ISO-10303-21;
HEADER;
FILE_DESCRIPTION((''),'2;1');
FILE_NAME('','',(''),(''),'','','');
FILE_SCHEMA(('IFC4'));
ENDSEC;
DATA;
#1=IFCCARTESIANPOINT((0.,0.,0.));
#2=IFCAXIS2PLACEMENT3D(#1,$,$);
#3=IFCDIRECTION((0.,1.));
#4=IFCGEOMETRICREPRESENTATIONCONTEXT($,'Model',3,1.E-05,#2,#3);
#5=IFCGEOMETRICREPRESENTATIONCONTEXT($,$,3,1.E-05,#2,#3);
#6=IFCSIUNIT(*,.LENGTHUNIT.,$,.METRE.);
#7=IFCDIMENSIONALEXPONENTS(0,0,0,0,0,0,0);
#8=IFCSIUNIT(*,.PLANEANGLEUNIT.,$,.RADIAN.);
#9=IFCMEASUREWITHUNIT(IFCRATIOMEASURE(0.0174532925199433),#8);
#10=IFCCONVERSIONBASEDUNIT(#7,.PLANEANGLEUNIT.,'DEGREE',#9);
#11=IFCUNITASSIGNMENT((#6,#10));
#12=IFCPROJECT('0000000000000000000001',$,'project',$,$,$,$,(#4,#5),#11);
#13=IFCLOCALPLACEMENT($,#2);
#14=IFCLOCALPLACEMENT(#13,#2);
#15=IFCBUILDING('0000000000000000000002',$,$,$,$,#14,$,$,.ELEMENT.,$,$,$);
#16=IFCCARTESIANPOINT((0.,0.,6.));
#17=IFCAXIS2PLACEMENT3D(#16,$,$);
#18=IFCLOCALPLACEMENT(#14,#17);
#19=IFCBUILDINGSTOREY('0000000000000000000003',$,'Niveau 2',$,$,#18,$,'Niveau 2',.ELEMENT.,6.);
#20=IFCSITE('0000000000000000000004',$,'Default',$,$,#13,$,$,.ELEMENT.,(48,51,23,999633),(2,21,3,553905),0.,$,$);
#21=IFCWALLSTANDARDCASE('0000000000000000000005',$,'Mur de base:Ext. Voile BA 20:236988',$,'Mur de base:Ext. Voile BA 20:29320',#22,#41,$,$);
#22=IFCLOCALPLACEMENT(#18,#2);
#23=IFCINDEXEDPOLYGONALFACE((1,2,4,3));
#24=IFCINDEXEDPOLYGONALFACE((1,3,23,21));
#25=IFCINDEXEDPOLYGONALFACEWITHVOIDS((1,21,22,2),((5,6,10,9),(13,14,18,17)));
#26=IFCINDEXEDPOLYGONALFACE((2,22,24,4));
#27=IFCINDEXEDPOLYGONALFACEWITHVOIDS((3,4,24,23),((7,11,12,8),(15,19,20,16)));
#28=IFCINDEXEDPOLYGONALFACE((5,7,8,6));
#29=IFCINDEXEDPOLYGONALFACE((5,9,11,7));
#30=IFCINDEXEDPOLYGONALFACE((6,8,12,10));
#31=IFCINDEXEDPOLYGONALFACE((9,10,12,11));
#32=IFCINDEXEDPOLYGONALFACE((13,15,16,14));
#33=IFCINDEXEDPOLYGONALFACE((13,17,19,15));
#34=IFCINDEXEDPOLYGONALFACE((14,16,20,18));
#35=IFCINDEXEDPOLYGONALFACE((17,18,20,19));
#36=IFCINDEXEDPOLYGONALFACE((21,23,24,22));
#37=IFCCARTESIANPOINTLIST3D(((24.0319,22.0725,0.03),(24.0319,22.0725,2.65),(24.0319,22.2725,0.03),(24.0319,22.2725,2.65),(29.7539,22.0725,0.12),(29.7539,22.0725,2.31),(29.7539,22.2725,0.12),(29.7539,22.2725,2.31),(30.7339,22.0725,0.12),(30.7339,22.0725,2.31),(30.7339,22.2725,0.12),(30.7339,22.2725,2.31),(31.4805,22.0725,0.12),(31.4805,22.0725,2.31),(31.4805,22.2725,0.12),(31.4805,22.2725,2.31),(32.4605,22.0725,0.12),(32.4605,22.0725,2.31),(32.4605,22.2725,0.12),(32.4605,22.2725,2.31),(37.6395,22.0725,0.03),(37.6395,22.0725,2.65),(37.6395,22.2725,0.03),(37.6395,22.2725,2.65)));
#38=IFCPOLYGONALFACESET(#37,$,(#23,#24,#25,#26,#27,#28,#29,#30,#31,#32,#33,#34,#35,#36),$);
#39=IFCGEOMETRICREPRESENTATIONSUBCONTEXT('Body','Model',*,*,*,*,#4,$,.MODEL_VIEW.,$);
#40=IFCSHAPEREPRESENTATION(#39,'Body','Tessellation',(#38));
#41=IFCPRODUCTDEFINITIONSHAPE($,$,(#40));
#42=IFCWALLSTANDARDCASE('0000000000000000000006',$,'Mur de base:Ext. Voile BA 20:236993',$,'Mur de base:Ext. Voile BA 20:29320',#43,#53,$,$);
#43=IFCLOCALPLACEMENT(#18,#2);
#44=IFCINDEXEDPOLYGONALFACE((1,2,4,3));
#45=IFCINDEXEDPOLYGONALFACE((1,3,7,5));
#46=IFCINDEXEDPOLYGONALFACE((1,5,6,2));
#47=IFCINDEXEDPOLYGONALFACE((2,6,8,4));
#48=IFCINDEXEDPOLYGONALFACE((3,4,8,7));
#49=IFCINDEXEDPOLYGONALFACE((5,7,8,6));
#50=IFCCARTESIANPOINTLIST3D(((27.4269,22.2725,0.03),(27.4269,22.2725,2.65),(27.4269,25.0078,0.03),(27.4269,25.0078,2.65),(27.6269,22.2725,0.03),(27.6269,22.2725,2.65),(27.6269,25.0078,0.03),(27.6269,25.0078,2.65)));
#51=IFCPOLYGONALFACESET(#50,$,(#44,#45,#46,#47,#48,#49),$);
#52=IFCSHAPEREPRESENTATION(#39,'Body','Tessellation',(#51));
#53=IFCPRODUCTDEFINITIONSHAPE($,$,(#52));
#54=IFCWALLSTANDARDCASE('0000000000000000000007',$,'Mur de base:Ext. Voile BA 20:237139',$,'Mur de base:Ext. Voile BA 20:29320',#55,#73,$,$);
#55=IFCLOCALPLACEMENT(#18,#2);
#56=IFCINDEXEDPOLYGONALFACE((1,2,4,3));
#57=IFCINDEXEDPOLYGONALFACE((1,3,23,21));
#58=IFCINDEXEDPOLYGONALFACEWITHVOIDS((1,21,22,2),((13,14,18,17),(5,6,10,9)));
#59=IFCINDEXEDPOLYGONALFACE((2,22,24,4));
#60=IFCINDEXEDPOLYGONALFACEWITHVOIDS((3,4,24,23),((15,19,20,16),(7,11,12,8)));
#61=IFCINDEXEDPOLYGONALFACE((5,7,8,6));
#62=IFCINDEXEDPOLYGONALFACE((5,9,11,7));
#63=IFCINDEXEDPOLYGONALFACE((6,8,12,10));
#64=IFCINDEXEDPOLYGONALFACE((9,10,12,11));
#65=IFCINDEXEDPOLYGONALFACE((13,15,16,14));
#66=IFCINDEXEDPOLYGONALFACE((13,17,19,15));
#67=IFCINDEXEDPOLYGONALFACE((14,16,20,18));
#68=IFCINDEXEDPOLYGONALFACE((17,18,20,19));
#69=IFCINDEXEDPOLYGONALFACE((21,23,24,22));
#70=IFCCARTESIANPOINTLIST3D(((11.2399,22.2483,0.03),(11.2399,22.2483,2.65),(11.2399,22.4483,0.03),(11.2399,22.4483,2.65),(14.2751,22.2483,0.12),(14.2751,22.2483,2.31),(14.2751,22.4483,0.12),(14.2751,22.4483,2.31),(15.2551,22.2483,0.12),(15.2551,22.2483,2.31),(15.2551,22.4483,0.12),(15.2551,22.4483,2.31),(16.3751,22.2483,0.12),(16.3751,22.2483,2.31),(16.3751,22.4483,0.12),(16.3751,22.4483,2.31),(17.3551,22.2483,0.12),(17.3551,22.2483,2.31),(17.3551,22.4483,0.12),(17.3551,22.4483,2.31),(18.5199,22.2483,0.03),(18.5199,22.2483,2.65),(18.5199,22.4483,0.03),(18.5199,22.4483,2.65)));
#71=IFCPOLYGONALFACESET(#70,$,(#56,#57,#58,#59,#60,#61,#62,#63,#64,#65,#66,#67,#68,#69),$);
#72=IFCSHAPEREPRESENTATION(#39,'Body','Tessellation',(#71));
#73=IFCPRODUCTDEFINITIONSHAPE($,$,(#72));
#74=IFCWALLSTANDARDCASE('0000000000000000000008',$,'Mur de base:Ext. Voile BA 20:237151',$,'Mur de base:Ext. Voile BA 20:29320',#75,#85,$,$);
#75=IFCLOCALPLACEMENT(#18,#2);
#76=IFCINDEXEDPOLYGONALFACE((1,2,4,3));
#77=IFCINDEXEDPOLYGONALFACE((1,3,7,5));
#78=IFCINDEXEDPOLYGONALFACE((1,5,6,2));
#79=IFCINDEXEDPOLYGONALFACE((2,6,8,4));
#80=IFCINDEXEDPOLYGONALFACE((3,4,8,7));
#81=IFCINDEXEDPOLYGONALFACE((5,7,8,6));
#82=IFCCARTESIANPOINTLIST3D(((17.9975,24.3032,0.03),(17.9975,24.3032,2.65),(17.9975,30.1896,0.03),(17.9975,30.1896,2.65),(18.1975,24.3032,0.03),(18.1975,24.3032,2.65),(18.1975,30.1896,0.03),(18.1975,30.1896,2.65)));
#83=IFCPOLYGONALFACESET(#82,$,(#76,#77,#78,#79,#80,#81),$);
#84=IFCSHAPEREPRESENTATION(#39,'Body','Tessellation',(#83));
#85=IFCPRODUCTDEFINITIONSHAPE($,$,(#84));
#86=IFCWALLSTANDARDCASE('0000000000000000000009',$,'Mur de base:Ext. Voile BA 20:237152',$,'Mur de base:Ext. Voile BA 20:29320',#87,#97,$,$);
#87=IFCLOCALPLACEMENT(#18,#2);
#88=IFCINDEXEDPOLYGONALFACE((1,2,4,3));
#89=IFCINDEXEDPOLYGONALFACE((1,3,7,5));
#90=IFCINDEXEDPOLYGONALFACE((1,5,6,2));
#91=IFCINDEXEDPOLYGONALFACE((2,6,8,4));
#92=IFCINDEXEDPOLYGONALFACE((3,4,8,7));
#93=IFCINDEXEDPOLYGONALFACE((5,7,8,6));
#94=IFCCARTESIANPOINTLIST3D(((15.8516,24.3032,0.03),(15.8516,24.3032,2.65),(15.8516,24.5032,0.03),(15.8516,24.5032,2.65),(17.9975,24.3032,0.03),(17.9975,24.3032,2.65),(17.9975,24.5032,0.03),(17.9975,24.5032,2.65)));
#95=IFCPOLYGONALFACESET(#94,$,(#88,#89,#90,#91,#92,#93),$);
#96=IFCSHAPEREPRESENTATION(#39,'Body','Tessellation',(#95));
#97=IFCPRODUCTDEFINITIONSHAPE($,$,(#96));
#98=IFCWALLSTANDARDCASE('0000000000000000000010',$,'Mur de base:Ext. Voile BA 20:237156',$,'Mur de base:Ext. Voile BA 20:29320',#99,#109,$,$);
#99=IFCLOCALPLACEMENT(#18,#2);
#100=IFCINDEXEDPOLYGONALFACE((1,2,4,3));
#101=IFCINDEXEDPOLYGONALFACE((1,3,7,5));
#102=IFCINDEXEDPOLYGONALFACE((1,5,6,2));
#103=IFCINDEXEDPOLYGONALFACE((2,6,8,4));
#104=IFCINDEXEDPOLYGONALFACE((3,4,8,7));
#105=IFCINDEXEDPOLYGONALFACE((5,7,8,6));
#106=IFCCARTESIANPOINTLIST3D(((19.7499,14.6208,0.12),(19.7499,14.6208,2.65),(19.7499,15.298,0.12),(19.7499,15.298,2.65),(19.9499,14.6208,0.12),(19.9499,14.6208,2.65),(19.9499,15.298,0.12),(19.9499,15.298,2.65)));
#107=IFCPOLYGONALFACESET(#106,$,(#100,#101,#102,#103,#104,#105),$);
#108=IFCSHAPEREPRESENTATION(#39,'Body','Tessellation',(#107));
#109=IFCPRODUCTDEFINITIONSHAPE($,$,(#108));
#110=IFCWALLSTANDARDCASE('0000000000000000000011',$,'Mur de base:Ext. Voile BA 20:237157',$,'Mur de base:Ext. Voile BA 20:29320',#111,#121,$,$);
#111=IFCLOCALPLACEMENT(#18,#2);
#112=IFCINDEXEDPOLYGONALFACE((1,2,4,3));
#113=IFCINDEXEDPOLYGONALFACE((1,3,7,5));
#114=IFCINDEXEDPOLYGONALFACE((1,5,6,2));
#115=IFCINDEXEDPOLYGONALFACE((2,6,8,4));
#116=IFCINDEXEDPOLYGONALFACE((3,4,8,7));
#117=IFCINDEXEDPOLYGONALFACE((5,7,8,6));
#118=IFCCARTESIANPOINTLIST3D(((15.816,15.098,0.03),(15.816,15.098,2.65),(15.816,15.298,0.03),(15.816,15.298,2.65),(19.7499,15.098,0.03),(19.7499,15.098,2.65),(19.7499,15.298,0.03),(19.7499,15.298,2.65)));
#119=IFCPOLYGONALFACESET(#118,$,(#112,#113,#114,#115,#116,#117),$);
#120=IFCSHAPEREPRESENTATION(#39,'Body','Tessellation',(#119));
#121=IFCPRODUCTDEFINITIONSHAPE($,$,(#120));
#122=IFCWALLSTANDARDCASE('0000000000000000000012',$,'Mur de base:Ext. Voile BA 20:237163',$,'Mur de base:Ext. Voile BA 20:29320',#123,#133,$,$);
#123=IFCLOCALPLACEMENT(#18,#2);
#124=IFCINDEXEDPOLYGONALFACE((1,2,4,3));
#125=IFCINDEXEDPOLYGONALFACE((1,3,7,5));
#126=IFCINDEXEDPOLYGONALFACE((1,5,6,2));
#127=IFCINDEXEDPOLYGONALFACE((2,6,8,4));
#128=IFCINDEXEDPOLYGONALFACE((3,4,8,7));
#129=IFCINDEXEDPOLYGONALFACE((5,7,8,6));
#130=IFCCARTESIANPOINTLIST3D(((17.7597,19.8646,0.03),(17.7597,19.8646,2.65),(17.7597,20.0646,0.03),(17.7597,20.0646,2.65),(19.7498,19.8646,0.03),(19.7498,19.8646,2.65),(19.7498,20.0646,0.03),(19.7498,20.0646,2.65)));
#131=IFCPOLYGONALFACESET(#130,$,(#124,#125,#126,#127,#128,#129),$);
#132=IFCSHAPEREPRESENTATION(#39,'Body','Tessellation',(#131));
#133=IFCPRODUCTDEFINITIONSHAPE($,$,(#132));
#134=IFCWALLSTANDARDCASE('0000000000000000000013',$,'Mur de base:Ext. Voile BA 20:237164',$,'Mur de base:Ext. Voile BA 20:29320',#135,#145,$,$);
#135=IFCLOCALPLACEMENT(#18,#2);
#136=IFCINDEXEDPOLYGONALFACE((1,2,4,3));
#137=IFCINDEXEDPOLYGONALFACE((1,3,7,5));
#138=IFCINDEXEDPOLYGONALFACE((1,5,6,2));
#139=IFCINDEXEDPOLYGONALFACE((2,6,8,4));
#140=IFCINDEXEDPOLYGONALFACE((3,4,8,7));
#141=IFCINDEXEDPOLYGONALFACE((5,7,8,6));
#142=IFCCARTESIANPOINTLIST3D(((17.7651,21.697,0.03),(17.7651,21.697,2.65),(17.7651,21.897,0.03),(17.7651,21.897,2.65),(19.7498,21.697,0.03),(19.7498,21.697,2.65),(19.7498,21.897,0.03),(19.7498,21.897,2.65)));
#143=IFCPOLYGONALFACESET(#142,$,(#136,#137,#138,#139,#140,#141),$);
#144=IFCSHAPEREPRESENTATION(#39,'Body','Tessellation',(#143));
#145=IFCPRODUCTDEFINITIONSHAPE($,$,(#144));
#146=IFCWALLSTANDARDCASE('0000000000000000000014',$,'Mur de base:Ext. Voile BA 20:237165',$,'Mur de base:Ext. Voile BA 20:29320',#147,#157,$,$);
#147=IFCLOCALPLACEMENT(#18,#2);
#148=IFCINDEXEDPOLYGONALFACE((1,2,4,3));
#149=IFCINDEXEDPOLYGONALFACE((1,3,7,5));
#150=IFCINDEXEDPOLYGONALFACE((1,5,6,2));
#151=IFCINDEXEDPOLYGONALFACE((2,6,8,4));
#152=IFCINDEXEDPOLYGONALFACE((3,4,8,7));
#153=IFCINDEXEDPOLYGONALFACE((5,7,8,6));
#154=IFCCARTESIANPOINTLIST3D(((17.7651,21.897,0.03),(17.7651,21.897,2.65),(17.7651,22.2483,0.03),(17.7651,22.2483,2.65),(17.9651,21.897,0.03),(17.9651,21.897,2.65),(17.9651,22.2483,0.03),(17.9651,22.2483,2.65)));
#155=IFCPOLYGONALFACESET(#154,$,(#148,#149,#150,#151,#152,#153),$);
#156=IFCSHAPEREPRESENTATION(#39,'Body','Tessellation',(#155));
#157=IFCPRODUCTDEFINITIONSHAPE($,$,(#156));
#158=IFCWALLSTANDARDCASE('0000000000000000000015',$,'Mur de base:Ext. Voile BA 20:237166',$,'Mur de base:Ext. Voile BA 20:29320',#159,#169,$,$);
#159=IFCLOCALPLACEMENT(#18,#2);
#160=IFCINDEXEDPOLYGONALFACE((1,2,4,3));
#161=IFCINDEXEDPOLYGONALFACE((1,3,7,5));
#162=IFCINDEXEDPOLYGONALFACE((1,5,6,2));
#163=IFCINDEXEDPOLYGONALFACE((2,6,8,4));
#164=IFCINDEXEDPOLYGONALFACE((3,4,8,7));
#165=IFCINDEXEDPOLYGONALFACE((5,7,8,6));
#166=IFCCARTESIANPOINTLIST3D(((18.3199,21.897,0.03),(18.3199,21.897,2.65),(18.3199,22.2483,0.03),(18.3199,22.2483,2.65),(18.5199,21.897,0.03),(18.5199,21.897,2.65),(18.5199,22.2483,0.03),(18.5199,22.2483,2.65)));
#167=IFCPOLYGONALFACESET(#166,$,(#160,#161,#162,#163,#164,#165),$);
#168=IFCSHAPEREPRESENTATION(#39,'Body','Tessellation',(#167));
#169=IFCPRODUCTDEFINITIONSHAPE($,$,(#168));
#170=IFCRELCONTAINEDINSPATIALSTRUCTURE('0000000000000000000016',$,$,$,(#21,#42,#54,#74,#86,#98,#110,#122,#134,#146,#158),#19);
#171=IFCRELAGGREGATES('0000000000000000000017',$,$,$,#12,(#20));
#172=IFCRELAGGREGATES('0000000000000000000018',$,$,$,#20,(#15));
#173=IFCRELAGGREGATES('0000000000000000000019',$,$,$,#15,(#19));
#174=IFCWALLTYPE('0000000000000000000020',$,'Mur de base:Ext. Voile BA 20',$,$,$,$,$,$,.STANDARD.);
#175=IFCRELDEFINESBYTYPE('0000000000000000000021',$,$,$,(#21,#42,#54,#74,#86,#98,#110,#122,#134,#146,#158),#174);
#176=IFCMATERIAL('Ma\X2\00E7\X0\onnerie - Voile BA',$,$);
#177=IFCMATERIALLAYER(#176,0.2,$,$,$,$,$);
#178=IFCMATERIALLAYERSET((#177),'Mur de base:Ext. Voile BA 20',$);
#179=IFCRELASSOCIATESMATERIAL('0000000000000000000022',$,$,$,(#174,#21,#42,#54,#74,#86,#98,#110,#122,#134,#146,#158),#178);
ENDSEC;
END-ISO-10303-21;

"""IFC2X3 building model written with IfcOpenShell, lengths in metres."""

from ifc_helpers import new_model, entity, si_unit, converted_unit, direction, frame, frame_2d, origin, origin_2d_with_axis, place, context, subcontext, project, spatial, rectangle, extrude, material, layer, layer_set, layer_usage, type_object, element, save


model = new_model("IFC2X3")

# Units and contexts
model_context = context("Model", 3, precision=1e-05, world=origin(), true_north=direction((0.0, 1.0)))
context_of_model = context(None, 3, precision=1e-05, world=origin(), true_north=direction((0.0, 1.0)))
body_context = subcontext(model_context, "Body", "Model", "MODEL_VIEW")
ifc_project = project(units=[si_unit("LENGTHUNIT", "METRE"), converted_unit("PLANEANGLEUNIT", "DEGREE", entity("IfcRatioMeasure", 0.0174532925199433), si_unit("PLANEANGLEUNIT", "RADIAN"), dimensions=[0, 0, 0, 0, 0, 0, 0])], contexts=[model_context, context_of_model])

# Site, building, storey
site_placement = place(None, origin())
site = spatial("IfcSite", under=ifc_project, at=site_placement, Name="Default", CompositionType="ELEMENT", RefLatitude=(48, 51, 23, 999633), RefLongitude=(2, 21, 3, 553905), RefElevation=0.0)
building_placement = place(site_placement, origin())
building = spatial("IfcBuilding", under=site, at=building_placement, CompositionType="ELEMENT")
storey_placement = place(building_placement, frame((0.0, 0.0, 6.0)))
storey = spatial("IfcBuildingStorey", under=building, at=storey_placement, Name="Niveau 2", LongName="Niveau 2", CompositionType="ELEMENT", Elevation=6.0)

# Wall, openings
ifc_material = material(Name="Maçonnerie - Voile BA")
ifc_layer_1 = layer(ifc_material, 0.2)
ifc_layer_set_1 = layer_set([ifc_layer_1], Name="Mur de base:Ext. Voile BA 20")
ifc_layer_usage_1 = layer_usage(ifc_layer_set_1, "AXIS2", "NEGATIVE", 0.1)
wall_type_1 = type_object("IfcWallType", Name="Mur de base:Ext. Voile BA 20", PredefinedType="STANDARD", material=ifc_layer_set_1)
wall_1_placement = place(storey_placement, frame((24.0319, 22.1725, 0.03)))
wall_1 = element("IfcWallStandardCase", 1, at=wall_1_placement, inside=storey, type_object=wall_type_1, material=ifc_layer_usage_1, Name="Mur de base:Ext. Voile BA 20:236988", ObjectType="Mur de base:Ext. Voile BA 20:29320", context=body_context, shape_type="SweptSolid", body=[
    extrude(rectangle(XDim=13.6075, YDim=0.2, at=frame_2d((6.8038, 0.0), x_axis=(-1.0, 0.0))), origin(), (0.0, 0.0, 1.0), 2.62),
])
opening_1_placement = place(wall_1_placement, origin())
element("IfcOpeningElement", 2, at=opening_1_placement, cuts=wall_1, ObjectType="Opening", context=body_context, shape_type="SweptSolid", body=[
    extrude(rectangle(XDim=2.19, YDim=0.98, at=origin_2d_with_axis()), frame((7.9385, -0.1, 1.185), z_axis=(0.0, 1.0, 0.0), x_axis=(0.0, 0.0, -1.0)), (0.0, 0.0, 1.0), 0.2),
])
opening_2_placement = place(wall_1_placement, origin())
element("IfcOpeningElement", 3, at=opening_2_placement, cuts=wall_1, ObjectType="Opening", context=body_context, shape_type="SweptSolid", body=[
    extrude(rectangle(XDim=2.19, YDim=0.98, at=origin_2d_with_axis()), frame((6.212, -0.1, 1.185), z_axis=(0.0, 1.0, 0.0), x_axis=(0.0, 0.0, -1.0)), (0.0, 0.0, 1.0), 0.2),
])

# Wall
ifc_layer_usage_2 = layer_usage(ifc_layer_set_1, "AXIS2", "NEGATIVE", 0.1)
wall_2_placement = place(storey_placement, frame((27.5269, 25.0078, 0.03), z_axis=(0.0, 0.0, 1.0), x_axis=(0.0, -1.0, 0.0)))
element("IfcWallStandardCase", 4, at=wall_2_placement, inside=storey, type_object=wall_type_1, material=ifc_layer_usage_2, Name="Mur de base:Ext. Voile BA 20:236993", ObjectType="Mur de base:Ext. Voile BA 20:29320", context=body_context, shape_type="SweptSolid", body=[
    extrude(rectangle(XDim=2.7353, YDim=0.2, at=frame_2d((1.3677, 0.0), x_axis=(-1.0, 0.0))), origin(), (0.0, 0.0, 1.0), 2.62),
])

# Wall, openings
ifc_layer_usage_3 = layer_usage(ifc_layer_set_1, "AXIS2", "NEGATIVE", 0.1)
wall_3_placement = place(storey_placement, frame((18.5199, 22.3483, 0.03), z_axis=(0.0, 0.0, 1.0), x_axis=(-1.0, 0.0, 0.0)))
wall_3 = element("IfcWallStandardCase", 5, at=wall_3_placement, inside=storey, type_object=wall_type_1, material=ifc_layer_usage_3, Name="Mur de base:Ext. Voile BA 20:237139", ObjectType="Mur de base:Ext. Voile BA 20:29320", context=body_context, shape_type="SweptSolid", body=[
    extrude(rectangle(XDim=7.28, YDim=0.2, at=frame_2d((3.64, 0.0), x_axis=(-1.0, 0.0))), origin(), (0.0, 0.0, 1.0), 2.62),
])
opening_3_placement = place(wall_3_placement, origin())
element("IfcOpeningElement", 6, at=opening_3_placement, cuts=wall_3, ObjectType="Opening", context=body_context, shape_type="SweptSolid", body=[
    extrude(rectangle(XDim=2.19, YDim=0.98, at=origin_2d_with_axis()), frame((3.7548, -0.1, 1.185), z_axis=(0.0, 1.0, 0.0), x_axis=(0.0, 0.0, -1.0)), (0.0, 0.0, 1.0), 0.2),
])
opening_4_placement = place(wall_3_placement, origin())
element("IfcOpeningElement", 7, at=opening_4_placement, cuts=wall_3, ObjectType="Opening", context=body_context, shape_type="SweptSolid", body=[
    extrude(rectangle(XDim=2.19, YDim=0.98, at=frame_2d((0.0, 0.0), x_axis=(1.0, 0.0))), frame((1.6548, -0.1, 1.185), z_axis=(0.0, 1.0, 0.0), x_axis=(0.0, 0.0, -1.0)), (0.0, 0.0, 1.0), 0.2),
])

# Walls
ifc_layer_usage_4 = layer_usage(ifc_layer_set_1, "AXIS2", "NEGATIVE", 0.1)
wall_4_placement = place(storey_placement, frame((18.0975, 30.1896, 0.03), z_axis=(0.0, 0.0, 1.0), x_axis=(0.0, -1.0, 0.0)))
element("IfcWallStandardCase", 8, at=wall_4_placement, inside=storey, type_object=wall_type_1, material=ifc_layer_usage_4, Name="Mur de base:Ext. Voile BA 20:237151", ObjectType="Mur de base:Ext. Voile BA 20:29320", context=body_context, shape_type="SweptSolid", body=[
    extrude(rectangle(XDim=5.8865, YDim=0.2, at=frame_2d((2.9432, 0.0), x_axis=(-1.0, 0.0))), origin(), (0.0, 0.0, 1.0), 2.62),
])
ifc_layer_usage_5 = layer_usage(ifc_layer_set_1, "AXIS2", "NEGATIVE", 0.1)
wall_5_placement = place(storey_placement, frame((17.9975, 24.4032, 0.03), z_axis=(0.0, 0.0, 1.0), x_axis=(-1.0, 0.0, 0.0)))
element("IfcWallStandardCase", 9, at=wall_5_placement, inside=storey, type_object=wall_type_1, material=ifc_layer_usage_5, Name="Mur de base:Ext. Voile BA 20:237152", ObjectType="Mur de base:Ext. Voile BA 20:29320", context=body_context, shape_type="SweptSolid", body=[
    extrude(rectangle(XDim=2.146, YDim=0.2, at=frame_2d((1.073, 0.0), x_axis=(-1.0, 0.0))), origin(), (0.0, 0.0, 1.0), 2.62),
])
ifc_layer_usage_6 = layer_usage(ifc_layer_set_1, "AXIS2", "NEGATIVE", 0.1)
wall_6_placement = place(storey_placement, frame((19.8499, 14.6208, 0.12), z_axis=(0.0, 0.0, 1.0), x_axis=(0.0, 1.0, 0.0)))
element("IfcWallStandardCase", 10, at=wall_6_placement, inside=storey, type_object=wall_type_1, material=ifc_layer_usage_6, Name="Mur de base:Ext. Voile BA 20:237156", ObjectType="Mur de base:Ext. Voile BA 20:29320", context=body_context, shape_type="SweptSolid", body=[
    extrude(rectangle(XDim=0.6771, YDim=0.2, at=frame_2d((0.3386, 0.0), x_axis=(-1.0, 0.0))), origin(), (0.0, 0.0, 1.0), 2.53),
])
ifc_layer_usage_7 = layer_usage(ifc_layer_set_1, "AXIS2", "NEGATIVE", 0.1)
wall_7_placement = place(storey_placement, frame((19.7499, 15.198, 0.03), z_axis=(0.0, 0.0, 1.0), x_axis=(-1.0, 0.0, 0.0)))
element("IfcWallStandardCase", 11, at=wall_7_placement, inside=storey, type_object=wall_type_1, material=ifc_layer_usage_7, Name="Mur de base:Ext. Voile BA 20:237157", ObjectType="Mur de base:Ext. Voile BA 20:29320", context=body_context, shape_type="SweptSolid", body=[
    extrude(rectangle(XDim=3.9339, YDim=0.2, at=frame_2d((1.967, 0.0), x_axis=(-1.0, 0.0))), origin(), (0.0, 0.0, 1.0), 2.62),
])
ifc_layer_usage_8 = layer_usage(ifc_layer_set_1, "AXIS2", "NEGATIVE", 0.1)
wall_8_placement = place(storey_placement, frame((19.7498, 19.9646, 0.03), z_axis=(0.0, 0.0, 1.0), x_axis=(-1.0, 0.0, 0.0)))
element("IfcWallStandardCase", 12, at=wall_8_placement, inside=storey, type_object=wall_type_1, material=ifc_layer_usage_8, Name="Mur de base:Ext. Voile BA 20:237163", ObjectType="Mur de base:Ext. Voile BA 20:29320", context=body_context, shape_type="SweptSolid", body=[
    extrude(rectangle(XDim=1.9901, YDim=0.2, at=frame_2d((0.9951, 0.0), x_axis=(-1.0, 0.0))), origin(), (0.0, 0.0, 1.0), 2.62),
])
ifc_layer_usage_9 = layer_usage(ifc_layer_set_1, "AXIS2", "NEGATIVE", 0.1)
wall_9_placement = place(storey_placement, frame((19.7498, 21.797, 0.03), z_axis=(0.0, 0.0, 1.0), x_axis=(-1.0, 0.0, 0.0)))
element("IfcWallStandardCase", 13, at=wall_9_placement, inside=storey, type_object=wall_type_1, material=ifc_layer_usage_9, Name="Mur de base:Ext. Voile BA 20:237164", ObjectType="Mur de base:Ext. Voile BA 20:29320", context=body_context, shape_type="SweptSolid", body=[
    extrude(rectangle(XDim=1.9848, YDim=0.2, at=frame_2d((0.9924, 0.0), x_axis=(-1.0, 0.0))), origin(), (0.0, 0.0, 1.0), 2.62),
])
ifc_layer_usage_10 = layer_usage(ifc_layer_set_1, "AXIS2", "NEGATIVE", 0.1)
wall_10_placement = place(storey_placement, frame((17.8651, 22.2483, 0.03), z_axis=(0.0, 0.0, 1.0), x_axis=(0.0, -1.0, 0.0)))
element("IfcWallStandardCase", 14, at=wall_10_placement, inside=storey, type_object=wall_type_1, material=ifc_layer_usage_10, Name="Mur de base:Ext. Voile BA 20:237165", ObjectType="Mur de base:Ext. Voile BA 20:29320", context=body_context, shape_type="SweptSolid", body=[
    extrude(rectangle(XDim=0.3513, YDim=0.2, at=frame_2d((0.1756, 0.0), x_axis=(-1.0, 0.0))), origin(), (0.0, 0.0, 1.0), 2.62),
])
ifc_layer_usage_11 = layer_usage(ifc_layer_set_1, "AXIS2", "NEGATIVE", 0.1)
wall_11_placement = place(storey_placement, frame((18.4199, 22.2483, 0.03), z_axis=(0.0, 0.0, 1.0), x_axis=(0.0, -1.0, 0.0)))
element("IfcWallStandardCase", 15, at=wall_11_placement, inside=storey, type_object=wall_type_1, material=ifc_layer_usage_11, Name="Mur de base:Ext. Voile BA 20:237166", ObjectType="Mur de base:Ext. Voile BA 20:29320", context=body_context, shape_type="SweptSolid", body=[
    extrude(rectangle(XDim=0.3513, YDim=0.2, at=frame_2d((0.1756, 0.0), x_axis=(-1.0, 0.0))), origin(), (0.0, 0.0, 1.0), 2.62),
])

save(model, "model.ifc")
